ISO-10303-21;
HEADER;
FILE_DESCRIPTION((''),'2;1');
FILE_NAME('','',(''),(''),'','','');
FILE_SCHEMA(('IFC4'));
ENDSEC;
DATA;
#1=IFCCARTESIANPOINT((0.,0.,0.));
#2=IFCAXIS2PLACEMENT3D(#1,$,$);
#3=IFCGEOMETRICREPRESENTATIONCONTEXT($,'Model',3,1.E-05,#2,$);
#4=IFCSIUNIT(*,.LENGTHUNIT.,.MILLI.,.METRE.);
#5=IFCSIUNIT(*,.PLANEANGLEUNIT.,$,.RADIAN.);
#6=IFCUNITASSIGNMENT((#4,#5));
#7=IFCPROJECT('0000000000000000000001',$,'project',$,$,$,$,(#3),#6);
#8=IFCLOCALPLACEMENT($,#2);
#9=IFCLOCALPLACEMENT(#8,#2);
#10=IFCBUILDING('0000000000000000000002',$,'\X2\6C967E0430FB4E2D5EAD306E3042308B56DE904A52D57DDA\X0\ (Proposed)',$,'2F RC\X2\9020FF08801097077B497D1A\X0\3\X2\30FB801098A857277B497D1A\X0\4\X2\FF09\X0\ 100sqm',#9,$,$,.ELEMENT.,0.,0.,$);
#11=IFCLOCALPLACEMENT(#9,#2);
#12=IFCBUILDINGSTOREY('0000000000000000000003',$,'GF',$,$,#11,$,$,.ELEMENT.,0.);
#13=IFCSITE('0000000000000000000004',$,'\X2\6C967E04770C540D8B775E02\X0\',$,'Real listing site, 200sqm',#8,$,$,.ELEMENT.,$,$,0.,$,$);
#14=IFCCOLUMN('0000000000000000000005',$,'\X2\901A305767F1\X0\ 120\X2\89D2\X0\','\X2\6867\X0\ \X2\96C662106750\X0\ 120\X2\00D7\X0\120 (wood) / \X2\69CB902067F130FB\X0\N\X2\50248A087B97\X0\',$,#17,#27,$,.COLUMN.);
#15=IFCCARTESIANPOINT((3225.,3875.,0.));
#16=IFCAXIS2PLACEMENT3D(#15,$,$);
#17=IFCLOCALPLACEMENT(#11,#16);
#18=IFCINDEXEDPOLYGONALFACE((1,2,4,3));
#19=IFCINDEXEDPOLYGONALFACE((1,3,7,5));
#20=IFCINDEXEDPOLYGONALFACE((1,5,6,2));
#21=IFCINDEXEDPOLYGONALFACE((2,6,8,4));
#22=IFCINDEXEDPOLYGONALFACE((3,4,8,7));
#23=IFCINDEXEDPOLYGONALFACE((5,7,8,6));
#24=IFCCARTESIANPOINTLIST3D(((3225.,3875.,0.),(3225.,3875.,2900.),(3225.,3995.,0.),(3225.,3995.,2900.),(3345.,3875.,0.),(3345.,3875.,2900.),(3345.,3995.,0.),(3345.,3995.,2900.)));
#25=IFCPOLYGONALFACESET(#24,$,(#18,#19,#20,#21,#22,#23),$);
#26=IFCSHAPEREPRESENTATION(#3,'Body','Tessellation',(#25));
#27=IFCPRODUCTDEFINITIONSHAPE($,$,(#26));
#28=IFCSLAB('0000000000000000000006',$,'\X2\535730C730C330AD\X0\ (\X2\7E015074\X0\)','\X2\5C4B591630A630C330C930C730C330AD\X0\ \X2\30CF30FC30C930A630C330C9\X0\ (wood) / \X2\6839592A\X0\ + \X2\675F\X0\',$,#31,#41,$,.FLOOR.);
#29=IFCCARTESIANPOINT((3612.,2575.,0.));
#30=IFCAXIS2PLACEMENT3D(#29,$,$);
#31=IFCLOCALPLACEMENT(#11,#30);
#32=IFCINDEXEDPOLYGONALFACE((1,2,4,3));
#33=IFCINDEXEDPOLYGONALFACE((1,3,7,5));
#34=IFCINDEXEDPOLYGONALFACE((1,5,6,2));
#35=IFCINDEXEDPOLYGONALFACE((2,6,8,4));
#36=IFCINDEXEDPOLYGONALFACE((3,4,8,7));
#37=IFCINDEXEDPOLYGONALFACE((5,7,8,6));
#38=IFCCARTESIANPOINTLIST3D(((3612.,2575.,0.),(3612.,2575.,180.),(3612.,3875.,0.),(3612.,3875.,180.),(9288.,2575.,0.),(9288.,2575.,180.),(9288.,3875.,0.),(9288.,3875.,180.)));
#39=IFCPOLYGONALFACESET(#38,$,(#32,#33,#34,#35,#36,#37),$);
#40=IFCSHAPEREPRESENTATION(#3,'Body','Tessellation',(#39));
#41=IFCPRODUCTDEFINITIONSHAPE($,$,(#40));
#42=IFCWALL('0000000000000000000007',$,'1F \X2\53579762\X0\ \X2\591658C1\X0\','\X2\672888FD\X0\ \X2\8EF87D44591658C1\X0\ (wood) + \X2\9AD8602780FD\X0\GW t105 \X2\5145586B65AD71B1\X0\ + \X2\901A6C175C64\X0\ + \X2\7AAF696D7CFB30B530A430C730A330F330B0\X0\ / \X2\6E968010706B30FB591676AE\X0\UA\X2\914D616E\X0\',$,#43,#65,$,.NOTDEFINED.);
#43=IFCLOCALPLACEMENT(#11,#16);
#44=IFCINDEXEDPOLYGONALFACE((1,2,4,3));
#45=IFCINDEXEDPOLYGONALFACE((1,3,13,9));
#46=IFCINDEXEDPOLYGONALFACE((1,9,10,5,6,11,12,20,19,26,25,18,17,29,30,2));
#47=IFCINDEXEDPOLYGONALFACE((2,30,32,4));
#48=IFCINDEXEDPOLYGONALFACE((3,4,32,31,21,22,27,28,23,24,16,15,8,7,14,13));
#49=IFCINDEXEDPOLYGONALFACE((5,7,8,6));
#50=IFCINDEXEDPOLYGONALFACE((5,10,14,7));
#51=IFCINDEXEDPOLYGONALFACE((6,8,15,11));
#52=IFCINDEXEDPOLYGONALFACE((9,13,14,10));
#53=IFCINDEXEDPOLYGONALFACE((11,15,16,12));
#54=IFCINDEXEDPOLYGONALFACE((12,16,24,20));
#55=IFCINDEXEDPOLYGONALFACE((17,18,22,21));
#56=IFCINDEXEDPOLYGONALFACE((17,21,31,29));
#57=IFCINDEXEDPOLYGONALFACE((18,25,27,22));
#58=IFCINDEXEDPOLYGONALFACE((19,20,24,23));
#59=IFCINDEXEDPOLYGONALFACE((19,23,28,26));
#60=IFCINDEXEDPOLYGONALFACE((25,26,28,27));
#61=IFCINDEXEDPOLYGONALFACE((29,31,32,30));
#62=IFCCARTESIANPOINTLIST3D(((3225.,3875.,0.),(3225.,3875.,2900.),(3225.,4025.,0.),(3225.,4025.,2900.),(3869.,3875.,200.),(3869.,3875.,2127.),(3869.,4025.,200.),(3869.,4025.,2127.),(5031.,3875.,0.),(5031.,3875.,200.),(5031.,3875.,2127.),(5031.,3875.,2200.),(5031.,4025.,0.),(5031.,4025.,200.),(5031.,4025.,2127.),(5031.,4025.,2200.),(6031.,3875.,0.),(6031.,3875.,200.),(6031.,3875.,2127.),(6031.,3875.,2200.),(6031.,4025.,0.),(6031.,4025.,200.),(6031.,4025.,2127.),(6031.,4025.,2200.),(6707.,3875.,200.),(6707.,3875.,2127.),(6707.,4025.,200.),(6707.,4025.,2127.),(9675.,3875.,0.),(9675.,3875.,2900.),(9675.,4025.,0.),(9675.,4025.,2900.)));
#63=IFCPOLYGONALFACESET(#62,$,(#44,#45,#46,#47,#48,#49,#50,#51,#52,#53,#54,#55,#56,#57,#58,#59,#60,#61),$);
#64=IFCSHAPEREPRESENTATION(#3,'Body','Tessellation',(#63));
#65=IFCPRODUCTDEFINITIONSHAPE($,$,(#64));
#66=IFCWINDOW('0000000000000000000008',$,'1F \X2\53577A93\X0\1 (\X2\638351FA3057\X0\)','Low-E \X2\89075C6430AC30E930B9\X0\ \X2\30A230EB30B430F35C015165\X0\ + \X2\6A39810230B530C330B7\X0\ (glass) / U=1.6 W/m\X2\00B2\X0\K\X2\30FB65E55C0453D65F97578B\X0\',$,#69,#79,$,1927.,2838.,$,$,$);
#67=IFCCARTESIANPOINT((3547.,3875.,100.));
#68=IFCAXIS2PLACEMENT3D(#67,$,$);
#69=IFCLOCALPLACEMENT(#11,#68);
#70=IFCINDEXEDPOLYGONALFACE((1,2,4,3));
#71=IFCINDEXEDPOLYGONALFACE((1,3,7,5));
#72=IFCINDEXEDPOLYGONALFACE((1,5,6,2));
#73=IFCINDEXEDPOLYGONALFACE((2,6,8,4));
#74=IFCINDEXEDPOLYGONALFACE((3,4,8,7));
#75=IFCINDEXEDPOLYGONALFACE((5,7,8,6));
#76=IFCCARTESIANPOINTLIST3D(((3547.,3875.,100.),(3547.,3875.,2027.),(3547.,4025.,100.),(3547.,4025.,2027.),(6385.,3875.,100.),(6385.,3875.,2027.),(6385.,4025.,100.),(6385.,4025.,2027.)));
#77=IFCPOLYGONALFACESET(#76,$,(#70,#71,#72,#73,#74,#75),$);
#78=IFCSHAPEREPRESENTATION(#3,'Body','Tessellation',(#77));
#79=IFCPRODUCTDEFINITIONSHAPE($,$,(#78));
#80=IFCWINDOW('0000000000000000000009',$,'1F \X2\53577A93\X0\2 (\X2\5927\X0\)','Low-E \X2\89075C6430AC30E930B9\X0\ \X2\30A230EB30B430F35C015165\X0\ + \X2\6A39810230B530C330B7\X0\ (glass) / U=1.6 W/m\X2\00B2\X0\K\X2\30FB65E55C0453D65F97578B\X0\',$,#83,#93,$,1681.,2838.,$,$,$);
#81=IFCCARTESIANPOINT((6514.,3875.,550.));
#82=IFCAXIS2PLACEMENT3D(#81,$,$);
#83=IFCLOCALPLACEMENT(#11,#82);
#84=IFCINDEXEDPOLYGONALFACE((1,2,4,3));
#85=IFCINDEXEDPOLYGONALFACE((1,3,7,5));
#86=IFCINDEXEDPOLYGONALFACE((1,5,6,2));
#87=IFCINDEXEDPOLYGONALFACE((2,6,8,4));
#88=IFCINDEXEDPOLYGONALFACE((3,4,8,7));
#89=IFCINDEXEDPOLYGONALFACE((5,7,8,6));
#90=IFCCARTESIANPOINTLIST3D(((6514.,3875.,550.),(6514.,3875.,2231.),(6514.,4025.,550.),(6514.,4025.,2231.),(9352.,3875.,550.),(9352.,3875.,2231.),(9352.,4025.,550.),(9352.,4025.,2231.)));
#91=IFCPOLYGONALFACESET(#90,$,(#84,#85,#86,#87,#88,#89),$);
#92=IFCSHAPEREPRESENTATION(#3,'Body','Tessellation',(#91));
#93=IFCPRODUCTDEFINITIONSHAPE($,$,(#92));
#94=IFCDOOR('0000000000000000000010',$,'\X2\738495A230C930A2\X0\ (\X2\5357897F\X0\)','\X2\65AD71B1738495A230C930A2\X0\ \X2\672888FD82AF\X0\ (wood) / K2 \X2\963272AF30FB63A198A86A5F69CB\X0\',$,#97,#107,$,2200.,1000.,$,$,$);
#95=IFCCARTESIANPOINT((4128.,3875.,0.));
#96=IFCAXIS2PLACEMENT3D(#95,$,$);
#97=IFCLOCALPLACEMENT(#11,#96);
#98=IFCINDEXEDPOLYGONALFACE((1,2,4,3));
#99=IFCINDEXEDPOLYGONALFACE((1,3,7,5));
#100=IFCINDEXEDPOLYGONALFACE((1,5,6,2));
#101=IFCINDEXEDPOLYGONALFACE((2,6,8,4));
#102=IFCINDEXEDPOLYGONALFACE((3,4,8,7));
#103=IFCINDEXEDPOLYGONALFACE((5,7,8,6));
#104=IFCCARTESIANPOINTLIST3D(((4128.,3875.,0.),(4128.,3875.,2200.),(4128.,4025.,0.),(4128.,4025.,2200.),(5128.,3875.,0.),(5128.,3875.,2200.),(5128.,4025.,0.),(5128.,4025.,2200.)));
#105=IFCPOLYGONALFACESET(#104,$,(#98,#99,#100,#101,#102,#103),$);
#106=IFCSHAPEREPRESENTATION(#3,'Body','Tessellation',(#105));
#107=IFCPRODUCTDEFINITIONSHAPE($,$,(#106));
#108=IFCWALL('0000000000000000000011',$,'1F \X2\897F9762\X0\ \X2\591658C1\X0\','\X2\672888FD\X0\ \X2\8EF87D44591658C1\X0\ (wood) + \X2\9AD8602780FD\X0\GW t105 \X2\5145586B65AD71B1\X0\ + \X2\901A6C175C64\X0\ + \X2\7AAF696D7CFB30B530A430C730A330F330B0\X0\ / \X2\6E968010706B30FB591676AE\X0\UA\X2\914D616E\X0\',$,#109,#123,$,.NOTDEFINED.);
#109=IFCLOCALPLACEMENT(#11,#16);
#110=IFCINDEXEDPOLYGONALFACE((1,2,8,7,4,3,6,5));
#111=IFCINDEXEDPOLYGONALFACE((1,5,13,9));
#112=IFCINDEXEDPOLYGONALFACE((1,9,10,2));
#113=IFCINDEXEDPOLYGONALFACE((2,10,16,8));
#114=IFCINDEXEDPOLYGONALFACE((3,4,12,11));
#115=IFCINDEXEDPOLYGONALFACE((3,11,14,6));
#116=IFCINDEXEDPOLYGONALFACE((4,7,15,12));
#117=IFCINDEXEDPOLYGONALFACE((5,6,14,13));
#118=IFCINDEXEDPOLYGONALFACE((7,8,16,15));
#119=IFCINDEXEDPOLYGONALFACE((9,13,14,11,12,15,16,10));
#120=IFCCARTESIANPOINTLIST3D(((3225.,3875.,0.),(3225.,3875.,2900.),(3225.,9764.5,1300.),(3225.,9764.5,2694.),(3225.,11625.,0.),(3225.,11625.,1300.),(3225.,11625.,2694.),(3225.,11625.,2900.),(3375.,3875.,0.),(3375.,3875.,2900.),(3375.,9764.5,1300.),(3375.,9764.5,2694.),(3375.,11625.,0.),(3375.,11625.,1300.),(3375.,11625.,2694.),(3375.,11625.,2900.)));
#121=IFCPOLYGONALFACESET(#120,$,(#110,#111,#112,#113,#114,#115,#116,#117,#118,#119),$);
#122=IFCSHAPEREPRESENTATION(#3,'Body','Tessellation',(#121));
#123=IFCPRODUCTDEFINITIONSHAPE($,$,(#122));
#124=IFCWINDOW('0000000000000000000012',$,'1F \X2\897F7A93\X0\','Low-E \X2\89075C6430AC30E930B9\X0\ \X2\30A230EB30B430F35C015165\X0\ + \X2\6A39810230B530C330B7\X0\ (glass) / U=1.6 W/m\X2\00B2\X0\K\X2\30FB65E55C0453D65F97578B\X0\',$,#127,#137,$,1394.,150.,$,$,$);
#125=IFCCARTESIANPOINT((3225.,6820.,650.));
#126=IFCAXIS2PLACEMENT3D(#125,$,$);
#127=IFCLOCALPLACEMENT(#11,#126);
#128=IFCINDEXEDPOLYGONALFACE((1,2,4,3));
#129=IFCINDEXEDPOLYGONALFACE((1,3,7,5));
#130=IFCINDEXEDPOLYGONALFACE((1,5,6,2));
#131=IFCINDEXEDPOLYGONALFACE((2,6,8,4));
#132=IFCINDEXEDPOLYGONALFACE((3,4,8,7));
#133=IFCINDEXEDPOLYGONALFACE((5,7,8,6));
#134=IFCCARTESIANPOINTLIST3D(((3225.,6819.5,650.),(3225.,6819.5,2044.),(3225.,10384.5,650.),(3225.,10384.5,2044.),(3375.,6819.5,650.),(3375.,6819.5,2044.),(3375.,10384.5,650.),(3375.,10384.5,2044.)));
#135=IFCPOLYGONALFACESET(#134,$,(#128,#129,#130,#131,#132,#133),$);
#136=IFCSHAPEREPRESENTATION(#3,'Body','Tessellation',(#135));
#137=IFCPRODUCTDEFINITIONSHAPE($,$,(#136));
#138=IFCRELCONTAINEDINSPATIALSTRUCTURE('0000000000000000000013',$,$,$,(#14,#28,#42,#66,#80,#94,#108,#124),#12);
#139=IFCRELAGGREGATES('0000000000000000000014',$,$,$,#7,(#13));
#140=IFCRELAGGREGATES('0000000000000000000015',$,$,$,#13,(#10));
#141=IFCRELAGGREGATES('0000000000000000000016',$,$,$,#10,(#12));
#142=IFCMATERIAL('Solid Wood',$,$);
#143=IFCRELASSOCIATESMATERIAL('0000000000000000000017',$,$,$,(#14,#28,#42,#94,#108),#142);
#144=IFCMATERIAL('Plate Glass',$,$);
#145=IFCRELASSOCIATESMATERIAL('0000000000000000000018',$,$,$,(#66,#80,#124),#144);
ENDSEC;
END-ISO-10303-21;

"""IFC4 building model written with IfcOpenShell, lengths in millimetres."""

from ifc_helpers import new_model, si_unit, frame, frame_2d, origin, place, context, project, spatial, rectangle, extrude, material, element, fill, save


model = new_model("IFC4")

# Units and contexts
model_context = context("Model", 3, precision=1e-05, world=origin())
ifc_project = project(units=[si_unit("LENGTHUNIT", "METRE", prefix="MILLI"), si_unit("PLANEANGLEUNIT", "RADIAN")], contexts=[model_context])

# Site, building, storey
site_placement = place(None, origin())
site = spatial("IfcSite", under=ifc_project, at=site_placement, Name="沖縄県名護市", ObjectType="Real listing site, 200sqm", CompositionType="ELEMENT", RefElevation=0.0)
building_placement = place(site_placement, origin())
building = spatial("IfcBuilding", under=site, at=building_placement, Name="沖縄・中庭のある回遊動線 (Proposed)", ObjectType="2F RC造（耐震等級3・耐風圧等級4） 100sqm", CompositionType="ELEMENT", ElevationOfRefHeight=0.0, ElevationOfTerrain=0.0)
storey_placement = place(building_placement, origin())
storey = spatial("IfcBuildingStorey", under=building, at=storey_placement, Name="GF", CompositionType="ELEMENT", Elevation=0.0)

# Column
ifc_material_1 = material(Name="Solid Wood")
column_placement = place(storey_placement, frame((3225.0, 3875.0, 0.0)))
element("IfcColumn", 1, at=column_placement, inside=storey, material=ifc_material_1, Name="通し柱 120角", Description="桧 集成材 120×120 (wood) / 構造柱・N値計算", PredefinedType="COLUMN", context=model_context, shape_type="SweptSolid", body=[
    extrude(rectangle(XDim=120.0, YDim=120.0, at=frame_2d((60.0, 60.0))), frame((3225.0, 3875.0, 0.0)), (0.0, 0.0, 1.0), 2900.0),
])

# Slab
slab_1_placement = place(storey_placement, frame((3612.0, 2575.0, 0.0)))
element("IfcSlab", 2, at=slab_1_placement, inside=storey, material=ifc_material_1, Name="南デッキ (縁側)", Description="屋外ウッドデッキ ハードウッド (wood) / 根太 + 束", PredefinedType="FLOOR", context=model_context, shape_type="SweptSolid", body=[
    extrude(rectangle(XDim=5676.0, YDim=1300.0, at=frame_2d((2838.0, 650.0))), frame((3612.0, 2575.0, 0.0)), (0.0, 0.0, 1.0), 180.0),
])

# Wall, openings, windows, door
wall_1_placement = place(storey_placement, frame((3225.0, 3875.0, 0.0)))
wall_1 = element("IfcWall", 3, at=wall_1_placement, inside=storey, material=ifc_material_1, Name="1F 南面 外壁", Description="木製 軸組外壁 (wood) + 高性能GW t105 充填断熱 + 通気層 + 窯業系サイディング / 準耐火・外皮UA配慮", PredefinedType="NOTDEFINED", context=model_context, shape_type="SweptSolid", body=[
    extrude(rectangle(XDim=6450.0, YDim=150.0, at=frame_2d((3225.0, 75.0))), frame((3225.0, 3875.0, 0.0)), (0.0, 0.0, 1.0), 2900.0),
])
opening_1_placement = place(storey_placement, frame((3547.0, 3875.0, 100.0)))
opening_1 = element("IfcOpeningElement", 4, at=opening_1_placement, cuts=wall_1, PredefinedType="NOTDEFINED", context=model_context, shape_type="SweptSolid", body=[
    extrude(rectangle(XDim=2838.0, YDim=150.0, at=frame_2d((1419.0, 75.0))), frame((3547.0, 3875.0, 100.0)), (0.0, 0.0, 1.0), 1927.0),
])
opening_2_placement = place(storey_placement, frame((6514.0, 3875.0, 550.0)))
opening_2 = element("IfcOpeningElement", 5, at=opening_2_placement, cuts=wall_1, PredefinedType="NOTDEFINED", context=model_context, shape_type="SweptSolid", body=[
    extrude(rectangle(XDim=2838.0, YDim=150.0, at=frame_2d((1419.0, 75.0))), frame((6514.0, 3875.0, 550.0)), (0.0, 0.0, 1.0), 1681.0),
])
opening_3_placement = place(storey_placement, frame((4128.0, 3875.0, 0.0)))
opening_3 = element("IfcOpeningElement", 6, at=opening_3_placement, cuts=wall_1, PredefinedType="NOTDEFINED", context=model_context, shape_type="SweptSolid", body=[
    extrude(rectangle(XDim=1000.0, YDim=150.0, at=frame_2d((500.0, 75.0))), frame((4128.0, 3875.0, 0.0)), (0.0, 0.0, 1.0), 2200.0),
])
ifc_material_2 = material(Name="Plate Glass")
window_1_placement = place(storey_placement, frame((3547.0, 3875.0, 100.0)))
window_1 = element("IfcWindow", 7, at=window_1_placement, inside=storey, material=ifc_material_2, Name="1F 南窓1 (掃出し)", Description="Low-E 複層ガラス アルゴン封入 + 樹脂サッシ (glass) / U=1.6 W/m²K・日射取得型", OverallHeight=1927.0, OverallWidth=2838.0, context=model_context, shape_type="SweptSolid", body=[
    extrude(rectangle(XDim=2838.0, YDim=150.0, at=frame_2d((1419.0, 75.0))), frame((3547.0, 3875.0, 100.0)), (0.0, 0.0, 1.0), 1927.0),
])
fill(opening_1, window_1)
window_2_placement = place(storey_placement, frame((6514.0, 3875.0, 550.0)))
window_2 = element("IfcWindow", 8, at=window_2_placement, inside=storey, material=ifc_material_2, Name="1F 南窓2 (大)", Description="Low-E 複層ガラス アルゴン封入 + 樹脂サッシ (glass) / U=1.6 W/m²K・日射取得型", OverallHeight=1681.0, OverallWidth=2838.0, context=model_context, shape_type="SweptSolid", body=[
    extrude(rectangle(XDim=2838.0, YDim=150.0, at=frame_2d((1419.0, 75.0))), frame((6514.0, 3875.0, 550.0)), (0.0, 0.0, 1.0), 1681.0),
])
fill(opening_2, window_2)
door_placement = place(storey_placement, frame((4128.0, 3875.0, 0.0)))
door = element("IfcDoor", 9, at=door_placement, inside=storey, material=ifc_material_1, Name="玄関ドア (南西)", Description="断熱玄関ドア 木製芯 (wood) / K2 防犯・採風機構", OverallHeight=2200.0, OverallWidth=1000.0, context=model_context, shape_type="SweptSolid", body=[
    extrude(rectangle(XDim=1000.0, YDim=150.0, at=frame_2d((500.0, 75.0))), frame((4128.0, 3875.0, 0.0)), (0.0, 0.0, 1.0), 2200.0),
])
fill(opening_3, door)

# Wall, opening, window
wall_2_placement = place(storey_placement, frame((3225.0, 3875.0, 0.0)))
wall_2 = element("IfcWall", 10, at=wall_2_placement, inside=storey, material=ifc_material_1, Name="1F 西面 外壁", Description="木製 軸組外壁 (wood) + 高性能GW t105 充填断熱 + 通気層 + 窯業系サイディング / 準耐火・外皮UA配慮", PredefinedType="NOTDEFINED", context=model_context, shape_type="SweptSolid", body=[
    extrude(rectangle(XDim=150.0, YDim=7750.0, at=frame_2d((75.0, 3875.0))), frame((3225.0, 3875.0, 0.0)), (0.0, 0.0, 1.0), 2900.0),
])
opening_4_placement = place(storey_placement, frame((3225.0, 6820.0, 650.0)))
opening_4 = element("IfcOpeningElement", 11, at=opening_4_placement, cuts=wall_2, PredefinedType="NOTDEFINED", context=model_context, shape_type="SweptSolid", body=[
    extrude(rectangle(XDim=150.0, YDim=3565.0, at=frame_2d((75.0, 1782.0))), frame((3225.0, 6820.0, 650.0)), (0.0, 0.0, 1.0), 1394.0),
])
window_3_placement = place(storey_placement, frame((3225.0, 6820.0, 650.0)))
window_3 = element("IfcWindow", 12, at=window_3_placement, inside=storey, material=ifc_material_2, Name="1F 西窓", Description="Low-E 複層ガラス アルゴン封入 + 樹脂サッシ (glass) / U=1.6 W/m²K・日射取得型", OverallHeight=1394.0, OverallWidth=150.0, context=model_context, shape_type="SweptSolid", body=[
    extrude(rectangle(XDim=150.0, YDim=3565.0, at=frame_2d((75.0, 1782.0))), frame((3225.0, 6820.0, 650.0)), (0.0, 0.0, 1.0), 1394.0),
])
fill(opening_4, window_3)

save(model, "model.ifc")
